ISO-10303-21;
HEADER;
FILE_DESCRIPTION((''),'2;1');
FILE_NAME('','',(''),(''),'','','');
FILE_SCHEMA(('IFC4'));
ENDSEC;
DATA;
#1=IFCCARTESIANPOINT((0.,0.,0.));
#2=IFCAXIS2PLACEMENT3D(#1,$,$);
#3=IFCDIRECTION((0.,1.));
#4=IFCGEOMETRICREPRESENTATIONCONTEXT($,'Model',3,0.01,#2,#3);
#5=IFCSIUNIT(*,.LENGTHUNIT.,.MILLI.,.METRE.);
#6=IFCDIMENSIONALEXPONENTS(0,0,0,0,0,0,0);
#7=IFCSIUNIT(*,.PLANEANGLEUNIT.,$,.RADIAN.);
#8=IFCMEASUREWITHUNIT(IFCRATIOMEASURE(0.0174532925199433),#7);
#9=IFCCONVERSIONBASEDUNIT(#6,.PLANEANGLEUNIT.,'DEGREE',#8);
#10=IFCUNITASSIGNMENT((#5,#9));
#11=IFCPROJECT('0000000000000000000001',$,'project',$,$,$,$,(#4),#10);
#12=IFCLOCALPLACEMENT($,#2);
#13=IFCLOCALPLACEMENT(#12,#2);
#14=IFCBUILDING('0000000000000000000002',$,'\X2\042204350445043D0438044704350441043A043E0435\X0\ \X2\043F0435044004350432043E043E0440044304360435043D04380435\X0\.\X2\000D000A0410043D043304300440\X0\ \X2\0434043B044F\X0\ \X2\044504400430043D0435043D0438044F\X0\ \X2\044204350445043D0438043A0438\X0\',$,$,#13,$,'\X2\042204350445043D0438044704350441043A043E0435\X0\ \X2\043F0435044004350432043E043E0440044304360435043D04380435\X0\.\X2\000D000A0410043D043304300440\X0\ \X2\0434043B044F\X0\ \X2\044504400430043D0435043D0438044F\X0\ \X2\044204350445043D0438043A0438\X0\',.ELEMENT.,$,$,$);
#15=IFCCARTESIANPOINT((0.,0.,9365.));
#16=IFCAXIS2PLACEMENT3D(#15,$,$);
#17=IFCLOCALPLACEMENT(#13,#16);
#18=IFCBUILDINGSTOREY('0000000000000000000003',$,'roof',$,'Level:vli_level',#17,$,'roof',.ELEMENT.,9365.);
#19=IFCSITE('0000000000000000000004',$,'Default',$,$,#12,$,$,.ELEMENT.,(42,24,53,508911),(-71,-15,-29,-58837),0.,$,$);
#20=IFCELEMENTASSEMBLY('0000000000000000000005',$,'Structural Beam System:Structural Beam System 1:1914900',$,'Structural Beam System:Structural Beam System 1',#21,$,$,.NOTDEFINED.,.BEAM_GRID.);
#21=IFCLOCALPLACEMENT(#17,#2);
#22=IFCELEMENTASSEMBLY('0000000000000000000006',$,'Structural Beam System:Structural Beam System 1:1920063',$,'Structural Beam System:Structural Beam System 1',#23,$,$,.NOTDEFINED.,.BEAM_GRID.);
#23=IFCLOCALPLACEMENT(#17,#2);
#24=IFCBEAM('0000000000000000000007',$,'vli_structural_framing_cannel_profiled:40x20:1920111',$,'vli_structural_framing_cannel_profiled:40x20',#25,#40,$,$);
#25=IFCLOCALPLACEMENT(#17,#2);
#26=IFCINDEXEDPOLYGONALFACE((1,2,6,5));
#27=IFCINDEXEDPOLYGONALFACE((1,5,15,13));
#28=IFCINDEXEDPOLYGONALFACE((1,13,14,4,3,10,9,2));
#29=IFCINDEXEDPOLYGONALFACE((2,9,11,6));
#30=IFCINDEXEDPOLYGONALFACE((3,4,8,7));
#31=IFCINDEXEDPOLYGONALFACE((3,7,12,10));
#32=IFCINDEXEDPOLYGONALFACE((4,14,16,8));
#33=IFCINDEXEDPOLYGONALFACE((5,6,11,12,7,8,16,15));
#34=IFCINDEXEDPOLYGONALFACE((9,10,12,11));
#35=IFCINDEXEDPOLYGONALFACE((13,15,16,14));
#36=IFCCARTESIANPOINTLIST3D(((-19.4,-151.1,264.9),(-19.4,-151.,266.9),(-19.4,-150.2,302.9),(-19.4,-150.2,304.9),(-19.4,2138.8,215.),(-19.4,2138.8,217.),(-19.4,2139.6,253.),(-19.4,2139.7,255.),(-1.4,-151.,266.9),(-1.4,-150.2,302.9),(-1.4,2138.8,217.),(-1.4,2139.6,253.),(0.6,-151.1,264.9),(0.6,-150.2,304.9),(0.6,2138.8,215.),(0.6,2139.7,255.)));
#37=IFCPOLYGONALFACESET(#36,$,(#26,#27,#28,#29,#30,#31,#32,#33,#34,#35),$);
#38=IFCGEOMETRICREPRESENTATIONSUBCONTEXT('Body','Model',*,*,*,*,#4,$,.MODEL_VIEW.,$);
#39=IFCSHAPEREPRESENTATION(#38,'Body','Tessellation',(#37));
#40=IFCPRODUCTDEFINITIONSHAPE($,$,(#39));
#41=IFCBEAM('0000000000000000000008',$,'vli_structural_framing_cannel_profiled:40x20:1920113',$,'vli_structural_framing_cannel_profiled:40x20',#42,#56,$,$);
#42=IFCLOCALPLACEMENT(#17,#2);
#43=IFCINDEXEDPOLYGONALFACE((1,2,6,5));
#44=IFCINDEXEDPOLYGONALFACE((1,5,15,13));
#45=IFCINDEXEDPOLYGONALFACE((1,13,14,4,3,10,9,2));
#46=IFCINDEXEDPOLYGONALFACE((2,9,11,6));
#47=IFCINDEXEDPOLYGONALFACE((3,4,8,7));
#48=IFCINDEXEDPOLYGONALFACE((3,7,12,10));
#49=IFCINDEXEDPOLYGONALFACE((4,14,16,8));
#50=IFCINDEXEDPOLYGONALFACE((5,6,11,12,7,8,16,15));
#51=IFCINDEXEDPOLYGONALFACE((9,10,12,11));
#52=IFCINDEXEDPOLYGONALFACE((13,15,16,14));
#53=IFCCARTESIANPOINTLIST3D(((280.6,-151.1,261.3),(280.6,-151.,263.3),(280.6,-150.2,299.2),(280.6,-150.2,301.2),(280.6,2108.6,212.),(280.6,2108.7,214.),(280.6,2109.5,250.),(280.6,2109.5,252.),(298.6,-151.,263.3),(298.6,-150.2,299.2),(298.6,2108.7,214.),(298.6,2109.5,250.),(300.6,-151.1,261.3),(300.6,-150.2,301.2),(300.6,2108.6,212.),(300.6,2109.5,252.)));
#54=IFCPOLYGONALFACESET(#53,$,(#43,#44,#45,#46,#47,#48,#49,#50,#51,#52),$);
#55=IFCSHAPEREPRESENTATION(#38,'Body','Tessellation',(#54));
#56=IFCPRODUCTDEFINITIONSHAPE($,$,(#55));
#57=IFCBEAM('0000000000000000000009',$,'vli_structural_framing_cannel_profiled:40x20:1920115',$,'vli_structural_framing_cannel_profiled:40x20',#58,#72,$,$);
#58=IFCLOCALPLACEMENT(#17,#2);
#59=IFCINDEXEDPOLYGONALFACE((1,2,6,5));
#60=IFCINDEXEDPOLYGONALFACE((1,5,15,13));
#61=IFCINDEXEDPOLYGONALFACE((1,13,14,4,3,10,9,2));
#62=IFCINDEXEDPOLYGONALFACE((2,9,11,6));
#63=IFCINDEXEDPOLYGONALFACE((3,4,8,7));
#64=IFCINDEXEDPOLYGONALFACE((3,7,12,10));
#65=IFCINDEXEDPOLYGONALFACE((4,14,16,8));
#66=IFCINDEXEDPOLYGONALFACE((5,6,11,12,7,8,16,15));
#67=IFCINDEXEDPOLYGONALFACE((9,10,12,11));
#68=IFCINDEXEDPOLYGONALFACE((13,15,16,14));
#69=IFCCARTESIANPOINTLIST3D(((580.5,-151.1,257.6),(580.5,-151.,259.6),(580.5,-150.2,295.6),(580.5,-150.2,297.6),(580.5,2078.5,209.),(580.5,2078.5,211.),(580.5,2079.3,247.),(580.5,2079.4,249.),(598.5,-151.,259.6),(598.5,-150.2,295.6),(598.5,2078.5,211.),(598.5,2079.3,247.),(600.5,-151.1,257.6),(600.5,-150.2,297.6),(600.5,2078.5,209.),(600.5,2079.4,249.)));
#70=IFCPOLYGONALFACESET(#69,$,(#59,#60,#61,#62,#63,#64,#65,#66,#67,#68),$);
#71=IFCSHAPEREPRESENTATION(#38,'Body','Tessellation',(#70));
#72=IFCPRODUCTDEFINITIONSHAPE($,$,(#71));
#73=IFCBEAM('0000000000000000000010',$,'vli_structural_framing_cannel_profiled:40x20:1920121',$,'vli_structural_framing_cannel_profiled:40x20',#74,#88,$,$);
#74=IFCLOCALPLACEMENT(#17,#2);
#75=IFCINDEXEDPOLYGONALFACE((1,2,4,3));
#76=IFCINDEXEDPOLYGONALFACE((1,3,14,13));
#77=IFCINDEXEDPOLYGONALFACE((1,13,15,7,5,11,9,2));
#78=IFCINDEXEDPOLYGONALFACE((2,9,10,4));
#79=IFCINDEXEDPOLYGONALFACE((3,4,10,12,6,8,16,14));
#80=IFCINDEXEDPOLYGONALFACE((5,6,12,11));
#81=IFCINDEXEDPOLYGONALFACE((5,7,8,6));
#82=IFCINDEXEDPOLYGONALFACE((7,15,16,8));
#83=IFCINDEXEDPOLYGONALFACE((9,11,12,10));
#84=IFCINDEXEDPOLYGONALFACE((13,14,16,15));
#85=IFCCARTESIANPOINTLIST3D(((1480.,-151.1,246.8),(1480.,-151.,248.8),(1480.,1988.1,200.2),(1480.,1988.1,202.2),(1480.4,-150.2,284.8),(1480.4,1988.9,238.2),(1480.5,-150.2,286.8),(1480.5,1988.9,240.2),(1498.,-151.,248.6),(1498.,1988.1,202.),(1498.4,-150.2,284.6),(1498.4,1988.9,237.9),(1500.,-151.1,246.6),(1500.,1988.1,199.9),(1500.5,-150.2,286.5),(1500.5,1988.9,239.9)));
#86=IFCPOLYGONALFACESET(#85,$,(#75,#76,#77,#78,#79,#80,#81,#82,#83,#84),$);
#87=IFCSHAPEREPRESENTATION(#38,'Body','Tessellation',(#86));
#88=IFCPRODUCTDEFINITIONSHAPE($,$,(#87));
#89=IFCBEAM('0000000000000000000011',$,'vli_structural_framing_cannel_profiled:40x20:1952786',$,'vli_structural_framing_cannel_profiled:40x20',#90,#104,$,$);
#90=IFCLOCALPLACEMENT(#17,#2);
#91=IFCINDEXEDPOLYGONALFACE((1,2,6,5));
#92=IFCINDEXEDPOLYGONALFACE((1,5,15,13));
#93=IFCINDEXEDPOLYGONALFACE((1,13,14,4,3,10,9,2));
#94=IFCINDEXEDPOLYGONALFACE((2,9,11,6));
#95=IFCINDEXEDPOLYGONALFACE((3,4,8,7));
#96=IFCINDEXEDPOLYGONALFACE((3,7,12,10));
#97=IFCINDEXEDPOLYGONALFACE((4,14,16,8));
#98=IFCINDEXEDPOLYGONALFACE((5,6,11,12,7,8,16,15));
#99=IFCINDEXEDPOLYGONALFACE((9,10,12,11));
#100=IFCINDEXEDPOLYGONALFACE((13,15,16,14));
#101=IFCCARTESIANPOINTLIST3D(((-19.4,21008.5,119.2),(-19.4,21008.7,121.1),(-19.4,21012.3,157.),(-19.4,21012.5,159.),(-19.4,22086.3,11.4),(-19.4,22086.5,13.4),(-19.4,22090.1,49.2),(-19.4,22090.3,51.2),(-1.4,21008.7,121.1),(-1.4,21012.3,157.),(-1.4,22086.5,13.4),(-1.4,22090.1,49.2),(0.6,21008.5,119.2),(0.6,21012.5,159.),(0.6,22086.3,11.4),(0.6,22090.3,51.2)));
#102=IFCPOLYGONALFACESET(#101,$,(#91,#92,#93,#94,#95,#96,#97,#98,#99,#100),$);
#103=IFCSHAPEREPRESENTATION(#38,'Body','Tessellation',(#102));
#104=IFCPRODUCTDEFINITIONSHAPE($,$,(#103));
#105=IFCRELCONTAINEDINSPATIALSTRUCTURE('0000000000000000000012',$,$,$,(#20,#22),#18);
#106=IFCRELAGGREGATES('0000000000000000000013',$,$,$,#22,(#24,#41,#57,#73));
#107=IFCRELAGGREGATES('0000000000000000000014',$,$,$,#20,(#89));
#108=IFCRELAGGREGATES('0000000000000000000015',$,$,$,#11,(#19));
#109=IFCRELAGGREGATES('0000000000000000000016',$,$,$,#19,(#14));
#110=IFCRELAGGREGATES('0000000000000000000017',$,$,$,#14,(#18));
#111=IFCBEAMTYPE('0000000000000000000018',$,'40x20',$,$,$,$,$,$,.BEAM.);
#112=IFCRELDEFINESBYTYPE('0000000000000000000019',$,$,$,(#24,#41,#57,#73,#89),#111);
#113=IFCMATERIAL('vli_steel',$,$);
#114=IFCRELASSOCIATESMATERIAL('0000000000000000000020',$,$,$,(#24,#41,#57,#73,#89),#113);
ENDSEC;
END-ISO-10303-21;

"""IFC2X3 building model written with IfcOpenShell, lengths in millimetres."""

from ifc_helpers import new_model, entity, si_unit, converted_unit, direction, frame, origin, place, context, subcontext, project, spatial, polyline, outline, extrude, material, type_object, element, aggregate, save


model = new_model("IFC2X3")

# Units and contexts
model_context = context("Model", 3, precision=0.01, world=origin(), true_north=direction((0.0, 1.0)))
body_context = subcontext(model_context, "Body", "Model", "MODEL_VIEW")
ifc_project = project(units=[si_unit("LENGTHUNIT", "METRE", prefix="MILLI"), converted_unit("PLANEANGLEUNIT", "DEGREE", entity("IfcRatioMeasure", 0.0174532925199433), si_unit("PLANEANGLEUNIT", "RADIAN"), dimensions=[0, 0, 0, 0, 0, 0, 0])], contexts=[model_context])

# Site, building, storey
site_placement = place(None, origin())
site = spatial("IfcSite", under=ifc_project, at=site_placement, Name="Default", CompositionType="ELEMENT", RefLatitude=(42, 24, 53, 508911), RefLongitude=(-71, -15, -29, -58837), RefElevation=0.0)
building_placement = place(site_placement, origin())
building = spatial("IfcBuilding", under=site, at=building_placement, Name="Техническое перевооружение.\r\nАнгар для хранения техники", LongName="Техническое перевооружение.\r\nАнгар для хранения техники", CompositionType="ELEMENT")
storey_placement = place(building_placement, frame((0.0, 0.0, 9365.0)))
storey = spatial("IfcBuildingStorey", under=building, at=storey_placement, Name="roof", ObjectType="Level:vli_level", LongName="roof", CompositionType="ELEMENT", Elevation=9365.0)

# Element assemblies, beams
assembly_1_placement = place(storey_placement, origin())
assembly_1 = element("IfcElementAssembly", 1, at=assembly_1_placement, inside=storey, Name="Structural Beam System:Structural Beam System 1:1914900", ObjectType="Structural Beam System:Structural Beam System 1", AssemblyPlace="NOTDEFINED", PredefinedType="BEAM_GRID")
ifc_material = material(Name="vli_steel")
beam_type = type_object("IfcBeamType", Name="40x20", PredefinedType="BEAM")
assembly_2_placement = place(storey_placement, origin())
assembly_2 = element("IfcElementAssembly", 2, at=assembly_2_placement, inside=storey, Name="Structural Beam System:Structural Beam System 1:1920063", ObjectType="Structural Beam System:Structural Beam System 1", AssemblyPlace="NOTDEFINED", PredefinedType="BEAM_GRID")
beam_1_placement = place(assembly_2_placement, frame((0.0, 2140.3, 255.0), z_axis=(0.0, 0.021793, 0.999763), x_axis=(0.0, -0.999763, 0.021793)))
beam_1 = element("IfcBeam", 3, at=beam_1_placement, type_object=beam_type, material=ifc_material, Name="vli_structural_framing_cannel_profiled:40x20:1920111", ObjectType="vli_structural_framing_cannel_profiled:40x20", context=body_context, shape_type="SweptSolid", body=[
    extrude(outline(polyline([(-20.0, -9.5), (-18.0, -9.5), (-18.0, 8.5), (18.0, 8.5), (18.0, -9.5), (20.0, -9.5), (20.0, 10.5), (-20.0, 10.5), (-20.0, -9.5)])), frame((0.7, -9.9, -20.0), z_axis=(1.0, 0.0, 0.0), x_axis=(0.0, 0.0, -1.0)), (0.0, 0.0, 1.0), 2290.4),
])
beam_2_placement = place(assembly_2_placement, frame((300.0, 2110.2, 252.0), z_axis=(0.0, 0.021793, 0.999763), x_axis=(0.0, -0.999763, 0.021793)))
beam_2 = element("IfcBeam", 4, at=beam_2_placement, type_object=beam_type, material=ifc_material, Name="vli_structural_framing_cannel_profiled:40x20:1920113", ObjectType="vli_structural_framing_cannel_profiled:40x20", context=body_context, shape_type="SweptSolid", body=[
    extrude(outline(polyline([(-20.0, -9.5), (-18.0, -9.5), (-18.0, 8.5), (18.0, 8.5), (18.0, -9.5), (20.0, -9.5), (20.0, 10.5), (-20.0, 10.5), (-20.0, -9.5)])), frame((0.7, -9.9, -20.0), z_axis=(1.0, 0.0, 0.0), x_axis=(0.0, 0.0, -1.0)), (0.0, 0.0, 1.0), 2260.2),
])
beam_3_placement = place(assembly_2_placement, frame((599.9, 2080.0, 249.0), z_axis=(0.0, 0.021793, 0.999763), x_axis=(0.0, -0.999763, 0.021793)))
beam_3 = element("IfcBeam", 5, at=beam_3_placement, type_object=beam_type, material=ifc_material, Name="vli_structural_framing_cannel_profiled:40x20:1920115", ObjectType="vli_structural_framing_cannel_profiled:40x20", context=body_context, shape_type="SweptSolid", body=[
    extrude(outline(polyline([(-20.0, -9.5), (-18.0, -9.5), (-18.0, 8.5), (18.0, 8.5), (18.0, -9.5), (20.0, -9.5), (20.0, 10.5), (-20.0, 10.5), (-20.0, -9.5)])), frame((0.7, -9.9, -20.0), z_axis=(1.0, 0.0, 0.0), x_axis=(0.0, 0.0, -1.0)), (0.0, 0.0, 1.0), 2230.1),
])
beam_4_placement = place(assembly_2_placement, frame((1499.9, 1989.6, 239.9), z_axis=(0.0, 0.021793, 0.999763), x_axis=(0.0, -0.999763, 0.021793)))
beam_4 = element("IfcBeam", 6, at=beam_4_placement, type_object=beam_type, material=ifc_material, Name="vli_structural_framing_cannel_profiled:40x20:1920121", ObjectType="vli_structural_framing_cannel_profiled:40x20", context=body_context, shape_type="SweptSolid", body=[
    extrude(outline(polyline([(-10.5, -20.0), (9.5, -20.0), (9.5, -18.0), (-8.5, -18.0), (-8.5, 18.0), (9.5, 18.0), (9.5, 20.0), (-10.5, 20.0), (-10.5, -20.0)])), frame((0.7, -10.1, -19.9), z_axis=(1.0, 0.0, 0.0), x_axis=(0.0, -0.999925, 0.012237)), (0.0, 0.0, 1.0), 2139.6),
])
aggregate(assembly_2, [beam_1, beam_2, beam_3, beam_4])

# Beam
beam_5_placement = place(assembly_1_placement, frame((0.0, 22090.8, 10.9), z_axis=(0.0, 0.099504, 0.995037), x_axis=(0.0, -0.995037, 0.099504)))
beam_5 = element("IfcBeam", 7, at=beam_5_placement, type_object=beam_type, material=ifc_material, Name="vli_structural_framing_cannel_profiled:40x20:1952786", ObjectType="vli_structural_framing_cannel_profiled:40x20", context=body_context, shape_type="SweptSolid", body=[
    extrude(outline(polyline([(-20.0, -9.5), (-18.0, -9.5), (-18.0, 8.5), (18.0, 8.5), (18.0, -9.5), (20.0, -9.5), (20.0, 10.5), (-20.0, 10.5), (-20.0, -9.5)])), frame((4.6, -9.9, 20.0), z_axis=(1.0, 0.0, 0.0), x_axis=(0.0, 0.0, -1.0)), (0.0, 0.0, 1.0), 1083.2),
])
aggregate(assembly_1, [beam_5])

save(model, "model.ifc")
